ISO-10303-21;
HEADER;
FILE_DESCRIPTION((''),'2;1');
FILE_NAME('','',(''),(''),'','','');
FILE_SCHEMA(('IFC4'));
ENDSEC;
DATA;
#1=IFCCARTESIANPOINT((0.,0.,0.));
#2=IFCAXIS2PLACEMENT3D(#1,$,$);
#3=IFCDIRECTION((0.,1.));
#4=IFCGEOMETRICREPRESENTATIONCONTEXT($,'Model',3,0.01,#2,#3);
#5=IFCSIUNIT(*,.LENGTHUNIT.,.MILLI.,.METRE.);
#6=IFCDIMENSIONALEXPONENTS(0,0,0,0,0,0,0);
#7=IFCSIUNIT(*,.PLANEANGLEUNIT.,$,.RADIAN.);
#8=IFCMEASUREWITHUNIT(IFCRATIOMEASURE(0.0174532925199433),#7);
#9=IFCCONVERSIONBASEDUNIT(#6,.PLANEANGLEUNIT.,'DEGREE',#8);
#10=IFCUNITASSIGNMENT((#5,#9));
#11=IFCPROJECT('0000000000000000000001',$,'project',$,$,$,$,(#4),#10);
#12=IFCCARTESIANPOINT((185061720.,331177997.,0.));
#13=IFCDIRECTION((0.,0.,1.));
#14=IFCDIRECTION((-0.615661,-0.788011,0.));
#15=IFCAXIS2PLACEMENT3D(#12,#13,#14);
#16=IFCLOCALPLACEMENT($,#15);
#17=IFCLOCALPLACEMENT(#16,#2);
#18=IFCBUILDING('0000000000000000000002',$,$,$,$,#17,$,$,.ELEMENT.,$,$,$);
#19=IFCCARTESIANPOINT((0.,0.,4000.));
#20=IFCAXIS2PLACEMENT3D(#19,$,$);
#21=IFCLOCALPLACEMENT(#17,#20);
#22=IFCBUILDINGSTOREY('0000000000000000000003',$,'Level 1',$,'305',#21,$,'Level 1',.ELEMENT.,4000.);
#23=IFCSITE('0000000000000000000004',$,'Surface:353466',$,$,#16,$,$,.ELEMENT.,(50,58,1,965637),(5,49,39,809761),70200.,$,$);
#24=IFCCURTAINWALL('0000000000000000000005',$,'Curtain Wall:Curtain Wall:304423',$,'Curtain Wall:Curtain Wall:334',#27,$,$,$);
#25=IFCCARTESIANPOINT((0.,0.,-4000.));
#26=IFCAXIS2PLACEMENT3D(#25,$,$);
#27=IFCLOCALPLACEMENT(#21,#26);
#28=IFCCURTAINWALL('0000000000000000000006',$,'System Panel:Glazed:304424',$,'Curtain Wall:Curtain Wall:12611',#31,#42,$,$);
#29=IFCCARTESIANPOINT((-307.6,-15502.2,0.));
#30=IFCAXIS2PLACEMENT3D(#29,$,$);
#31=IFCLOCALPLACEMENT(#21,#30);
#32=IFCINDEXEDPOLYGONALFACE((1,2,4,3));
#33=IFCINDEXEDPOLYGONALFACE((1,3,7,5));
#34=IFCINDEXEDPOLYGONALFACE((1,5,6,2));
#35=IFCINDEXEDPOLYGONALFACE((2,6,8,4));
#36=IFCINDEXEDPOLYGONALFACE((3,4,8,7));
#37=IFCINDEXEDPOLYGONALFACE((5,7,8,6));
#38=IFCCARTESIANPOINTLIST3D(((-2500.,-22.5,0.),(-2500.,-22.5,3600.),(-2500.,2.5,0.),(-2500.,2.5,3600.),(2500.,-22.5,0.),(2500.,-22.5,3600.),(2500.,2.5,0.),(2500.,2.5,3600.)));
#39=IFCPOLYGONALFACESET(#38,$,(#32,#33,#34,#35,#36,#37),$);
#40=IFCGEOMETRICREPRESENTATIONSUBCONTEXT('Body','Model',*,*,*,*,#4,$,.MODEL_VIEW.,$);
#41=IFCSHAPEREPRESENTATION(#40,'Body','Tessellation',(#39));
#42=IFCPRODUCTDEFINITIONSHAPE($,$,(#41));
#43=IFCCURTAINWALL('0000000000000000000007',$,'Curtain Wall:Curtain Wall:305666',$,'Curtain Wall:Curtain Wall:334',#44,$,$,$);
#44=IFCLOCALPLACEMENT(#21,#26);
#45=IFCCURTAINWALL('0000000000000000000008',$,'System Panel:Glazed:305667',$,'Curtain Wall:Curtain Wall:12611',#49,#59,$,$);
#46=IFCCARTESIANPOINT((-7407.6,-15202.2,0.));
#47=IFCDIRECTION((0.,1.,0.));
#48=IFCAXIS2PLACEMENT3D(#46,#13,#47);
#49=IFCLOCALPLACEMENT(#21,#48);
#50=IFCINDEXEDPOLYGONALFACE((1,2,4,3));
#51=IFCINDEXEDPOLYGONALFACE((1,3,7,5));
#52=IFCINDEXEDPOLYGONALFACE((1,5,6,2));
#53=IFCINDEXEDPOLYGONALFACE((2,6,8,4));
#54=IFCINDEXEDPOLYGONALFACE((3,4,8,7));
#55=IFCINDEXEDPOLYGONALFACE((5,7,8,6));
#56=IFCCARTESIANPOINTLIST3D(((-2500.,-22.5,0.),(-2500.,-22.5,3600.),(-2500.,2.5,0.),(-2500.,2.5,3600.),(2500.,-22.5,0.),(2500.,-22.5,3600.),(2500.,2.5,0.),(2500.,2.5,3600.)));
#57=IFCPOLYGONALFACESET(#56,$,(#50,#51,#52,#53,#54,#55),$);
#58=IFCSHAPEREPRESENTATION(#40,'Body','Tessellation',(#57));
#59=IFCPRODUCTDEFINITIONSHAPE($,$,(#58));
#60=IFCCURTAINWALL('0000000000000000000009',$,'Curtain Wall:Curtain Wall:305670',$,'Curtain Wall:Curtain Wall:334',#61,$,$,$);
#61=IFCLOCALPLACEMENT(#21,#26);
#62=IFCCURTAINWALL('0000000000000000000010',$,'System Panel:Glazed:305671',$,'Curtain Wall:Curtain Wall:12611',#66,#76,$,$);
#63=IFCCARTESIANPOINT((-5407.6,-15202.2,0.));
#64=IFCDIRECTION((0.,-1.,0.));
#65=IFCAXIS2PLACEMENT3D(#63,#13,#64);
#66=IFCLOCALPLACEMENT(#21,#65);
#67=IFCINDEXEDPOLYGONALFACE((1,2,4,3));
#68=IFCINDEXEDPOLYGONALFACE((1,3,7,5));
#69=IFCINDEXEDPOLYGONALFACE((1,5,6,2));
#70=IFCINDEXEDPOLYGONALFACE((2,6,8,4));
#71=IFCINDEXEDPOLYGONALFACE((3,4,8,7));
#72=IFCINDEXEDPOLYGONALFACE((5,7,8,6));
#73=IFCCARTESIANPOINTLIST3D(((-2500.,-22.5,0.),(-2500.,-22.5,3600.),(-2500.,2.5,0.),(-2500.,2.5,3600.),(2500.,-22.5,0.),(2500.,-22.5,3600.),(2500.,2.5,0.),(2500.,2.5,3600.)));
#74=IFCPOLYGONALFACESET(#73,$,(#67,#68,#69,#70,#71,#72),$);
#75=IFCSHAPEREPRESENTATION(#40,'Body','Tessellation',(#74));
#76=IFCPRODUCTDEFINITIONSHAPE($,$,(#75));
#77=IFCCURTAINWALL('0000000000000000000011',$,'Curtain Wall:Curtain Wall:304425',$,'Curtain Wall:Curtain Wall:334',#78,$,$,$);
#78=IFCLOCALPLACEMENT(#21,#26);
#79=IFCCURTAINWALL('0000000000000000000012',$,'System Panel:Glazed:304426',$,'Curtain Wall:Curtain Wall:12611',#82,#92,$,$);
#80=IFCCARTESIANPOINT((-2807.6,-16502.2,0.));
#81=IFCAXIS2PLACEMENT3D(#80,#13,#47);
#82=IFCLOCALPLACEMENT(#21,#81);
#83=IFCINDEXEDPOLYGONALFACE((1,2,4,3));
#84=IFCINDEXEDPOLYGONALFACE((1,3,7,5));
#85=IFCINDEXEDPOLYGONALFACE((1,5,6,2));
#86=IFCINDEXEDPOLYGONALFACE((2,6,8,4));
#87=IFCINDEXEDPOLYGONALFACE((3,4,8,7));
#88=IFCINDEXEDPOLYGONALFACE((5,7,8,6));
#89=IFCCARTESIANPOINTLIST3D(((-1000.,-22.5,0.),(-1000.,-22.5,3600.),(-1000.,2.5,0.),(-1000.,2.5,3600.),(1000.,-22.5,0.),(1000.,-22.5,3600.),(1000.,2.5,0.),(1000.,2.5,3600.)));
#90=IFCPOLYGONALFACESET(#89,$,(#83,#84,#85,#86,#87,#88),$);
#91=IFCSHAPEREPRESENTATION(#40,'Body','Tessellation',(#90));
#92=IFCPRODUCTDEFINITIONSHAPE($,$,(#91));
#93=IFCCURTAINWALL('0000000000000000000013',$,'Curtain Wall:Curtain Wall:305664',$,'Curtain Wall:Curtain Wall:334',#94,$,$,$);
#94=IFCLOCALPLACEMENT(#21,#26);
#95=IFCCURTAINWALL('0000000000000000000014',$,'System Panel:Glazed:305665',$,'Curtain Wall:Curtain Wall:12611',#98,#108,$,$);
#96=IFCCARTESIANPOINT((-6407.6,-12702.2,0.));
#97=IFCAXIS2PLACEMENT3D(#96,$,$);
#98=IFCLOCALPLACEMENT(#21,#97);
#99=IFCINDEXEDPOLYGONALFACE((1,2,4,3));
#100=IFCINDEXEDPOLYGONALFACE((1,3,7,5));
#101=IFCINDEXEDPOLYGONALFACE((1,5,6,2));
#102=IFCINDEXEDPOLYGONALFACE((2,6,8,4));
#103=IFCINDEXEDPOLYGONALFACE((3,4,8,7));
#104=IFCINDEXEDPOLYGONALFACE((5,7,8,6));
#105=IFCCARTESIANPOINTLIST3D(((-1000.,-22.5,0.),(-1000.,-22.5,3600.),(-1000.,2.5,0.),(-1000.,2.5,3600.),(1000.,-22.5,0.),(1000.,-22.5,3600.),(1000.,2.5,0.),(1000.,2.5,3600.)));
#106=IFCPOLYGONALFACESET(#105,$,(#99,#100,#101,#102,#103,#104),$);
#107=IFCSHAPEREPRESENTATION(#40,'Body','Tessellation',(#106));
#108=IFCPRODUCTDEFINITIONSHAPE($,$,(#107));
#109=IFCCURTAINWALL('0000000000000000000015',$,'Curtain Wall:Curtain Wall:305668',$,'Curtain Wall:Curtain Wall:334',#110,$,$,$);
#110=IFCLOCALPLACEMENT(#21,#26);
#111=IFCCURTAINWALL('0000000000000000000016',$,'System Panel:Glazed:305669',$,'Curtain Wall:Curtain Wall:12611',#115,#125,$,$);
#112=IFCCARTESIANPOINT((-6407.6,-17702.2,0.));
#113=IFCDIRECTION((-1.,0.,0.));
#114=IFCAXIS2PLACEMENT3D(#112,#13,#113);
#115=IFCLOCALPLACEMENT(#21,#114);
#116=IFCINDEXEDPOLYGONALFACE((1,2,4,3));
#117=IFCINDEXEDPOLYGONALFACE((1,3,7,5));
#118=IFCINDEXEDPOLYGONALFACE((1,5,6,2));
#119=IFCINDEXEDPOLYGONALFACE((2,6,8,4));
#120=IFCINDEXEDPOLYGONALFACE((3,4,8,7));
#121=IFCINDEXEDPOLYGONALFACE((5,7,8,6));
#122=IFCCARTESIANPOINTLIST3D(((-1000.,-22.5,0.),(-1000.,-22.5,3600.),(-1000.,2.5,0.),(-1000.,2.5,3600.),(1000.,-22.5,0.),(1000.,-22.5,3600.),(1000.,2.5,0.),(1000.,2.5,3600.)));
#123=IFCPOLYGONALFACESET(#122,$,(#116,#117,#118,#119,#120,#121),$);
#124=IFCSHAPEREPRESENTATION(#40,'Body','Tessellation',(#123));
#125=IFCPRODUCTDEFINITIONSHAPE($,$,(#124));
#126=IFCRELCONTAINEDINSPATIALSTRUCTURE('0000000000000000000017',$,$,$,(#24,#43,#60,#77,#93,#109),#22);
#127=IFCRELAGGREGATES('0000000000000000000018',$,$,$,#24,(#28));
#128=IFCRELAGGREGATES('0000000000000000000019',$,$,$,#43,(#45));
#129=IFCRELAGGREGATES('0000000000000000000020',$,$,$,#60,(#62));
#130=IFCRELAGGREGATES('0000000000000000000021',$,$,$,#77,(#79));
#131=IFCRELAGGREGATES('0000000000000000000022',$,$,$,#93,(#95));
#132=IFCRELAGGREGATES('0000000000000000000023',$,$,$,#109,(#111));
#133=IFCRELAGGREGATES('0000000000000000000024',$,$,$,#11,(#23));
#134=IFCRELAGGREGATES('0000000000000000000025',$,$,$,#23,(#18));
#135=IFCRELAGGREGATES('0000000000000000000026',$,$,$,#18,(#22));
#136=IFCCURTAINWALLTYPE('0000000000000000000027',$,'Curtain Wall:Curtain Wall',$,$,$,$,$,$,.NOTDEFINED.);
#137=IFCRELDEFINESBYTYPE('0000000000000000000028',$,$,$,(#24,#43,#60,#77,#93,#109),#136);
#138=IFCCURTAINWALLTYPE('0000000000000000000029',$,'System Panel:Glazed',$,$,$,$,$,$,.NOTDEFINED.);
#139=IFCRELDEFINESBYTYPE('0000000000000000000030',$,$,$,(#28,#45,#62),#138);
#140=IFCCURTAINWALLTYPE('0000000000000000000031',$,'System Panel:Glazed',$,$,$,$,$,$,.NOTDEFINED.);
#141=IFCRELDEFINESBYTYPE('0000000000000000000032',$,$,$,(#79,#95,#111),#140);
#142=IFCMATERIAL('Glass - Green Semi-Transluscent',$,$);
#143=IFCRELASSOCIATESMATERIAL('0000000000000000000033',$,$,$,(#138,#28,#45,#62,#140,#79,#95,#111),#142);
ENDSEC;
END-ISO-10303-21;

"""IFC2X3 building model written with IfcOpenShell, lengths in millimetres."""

from ifc_helpers import new_model, entity, si_unit, converted_unit, direction, frame, origin, origin_2d_with_axis, place, context, subcontext, project, spatial, rectangle, extrude, source, transform, mapped, material, type_object, type_shapes, element, aggregate, save


model = new_model("IFC2X3")

# Units and contexts
model_context = context("Model", 3, precision=0.01, world=origin(), true_north=direction((0.0, 1.0)))
body_context = subcontext(model_context, "Body", "Model", "MODEL_VIEW")
ifc_project = project(units=[si_unit("LENGTHUNIT", "METRE", prefix="MILLI"), converted_unit("PLANEANGLEUNIT", "DEGREE", entity("IfcRatioMeasure", 0.0174532925199433), si_unit("PLANEANGLEUNIT", "RADIAN"), dimensions=[0, 0, 0, 0, 0, 0, 0])], contexts=[model_context])

# Site, building, storey
site_placement = place(None, frame((185061720.0, 331177997.0, 0.0), z_axis=(0.0, 0.0, 1.0), x_axis=(-0.615661, -0.788011, 0.0)))
site = spatial("IfcSite", under=ifc_project, at=site_placement, Name="Surface:353466", CompositionType="ELEMENT", RefLatitude=(50, 58, 1, 965637), RefLongitude=(5, 49, 39, 809761), RefElevation=70200.0)
building_placement = place(site_placement, origin())
building = spatial("IfcBuilding", under=site, at=building_placement, CompositionType="ELEMENT")
storey_placement = place(building_placement, frame((0.0, 0.0, 4000.0)))
storey = spatial("IfcBuildingStorey", under=building, at=storey_placement, Name="Level 1", ObjectType="305", LongName="Level 1", CompositionType="ELEMENT", Elevation=4000.0)

# Curtain walls
curtain_wall_type_1 = type_object("IfcCurtainWallType", Name="Curtain Wall:Curtain Wall", PredefinedType="NOTDEFINED")
curtain_wall_1_placement = place(storey_placement, frame((0.0, 0.0, -4000.0)))
curtain_wall_1 = element("IfcCurtainWall", 1, at=curtain_wall_1_placement, inside=storey, type_object=curtain_wall_type_1, Name="Curtain Wall:Curtain Wall:304423", ObjectType="Curtain Wall:Curtain Wall:334")
ifc_material_1 = material(Name="Glass - Green Semi-Transluscent")
curtain_wall_type_2 = type_object("IfcCurtainWallType", Name="System Panel:Glazed", PredefinedType="NOTDEFINED", material=ifc_material_1)
shared_shape_1 = source(origin(), body_context, "Body", "SweptSolid", [
    extrude(rectangle(XDim=25.0, YDim=5000.0, at=origin_2d_with_axis()), frame((0.0, -10.0, 0.0), z_axis=(0.0, 0.0, 1.0), x_axis=(0.0, 1.0, 0.0)), (0.0, 0.0, 1.0), 3600.0),
])
type_shapes(curtain_wall_type_2, [shared_shape_1])
curtain_wall_2_placement = place(storey_placement, frame((-307.6, -15502.2, 0.0)))
curtain_wall_2 = element("IfcCurtainWall", 2, at=curtain_wall_2_placement, type_object=curtain_wall_type_2, material=ifc_material_1, Name="System Panel:Glazed:304424", ObjectType="Curtain Wall:Curtain Wall:12611", context=body_context, shape_type="MappedRepresentation", body=[
    mapped(shared_shape_1, transform((0.0, 0.0, 0.0), scale=1.0)),
])
aggregate(curtain_wall_1, [curtain_wall_2])
curtain_wall_3_placement = place(storey_placement, frame((0.0, 0.0, -4000.0)))
curtain_wall_3 = element("IfcCurtainWall", 3, at=curtain_wall_3_placement, inside=storey, type_object=curtain_wall_type_1, Name="Curtain Wall:Curtain Wall:305666", ObjectType="Curtain Wall:Curtain Wall:334")
curtain_wall_4_placement = place(storey_placement, frame((-7407.6, -15202.2, 0.0), z_axis=(0.0, 0.0, 1.0), x_axis=(0.0, 1.0, 0.0)))
curtain_wall_4 = element("IfcCurtainWall", 4, at=curtain_wall_4_placement, type_object=curtain_wall_type_2, material=ifc_material_1, Name="System Panel:Glazed:305667", ObjectType="Curtain Wall:Curtain Wall:12611", context=body_context, shape_type="MappedRepresentation", body=[
    mapped(shared_shape_1, transform((0.0, 0.0, 0.0), scale=1.0)),
])
aggregate(curtain_wall_3, [curtain_wall_4])
curtain_wall_5_placement = place(storey_placement, frame((0.0, 0.0, -4000.0)))
curtain_wall_5 = element("IfcCurtainWall", 5, at=curtain_wall_5_placement, inside=storey, type_object=curtain_wall_type_1, Name="Curtain Wall:Curtain Wall:305670", ObjectType="Curtain Wall:Curtain Wall:334")
curtain_wall_6_placement = place(storey_placement, frame((-5407.6, -15202.2, 0.0), z_axis=(0.0, 0.0, 1.0), x_axis=(0.0, -1.0, 0.0)))
curtain_wall_6 = element("IfcCurtainWall", 6, at=curtain_wall_6_placement, type_object=curtain_wall_type_2, material=ifc_material_1, Name="System Panel:Glazed:305671", ObjectType="Curtain Wall:Curtain Wall:12611", context=body_context, shape_type="MappedRepresentation", body=[
    mapped(shared_shape_1, transform((0.0, 0.0, 0.0), scale=1.0)),
])
aggregate(curtain_wall_5, [curtain_wall_6])
curtain_wall_7_placement = place(storey_placement, frame((0.0, 0.0, -4000.0)))
curtain_wall_7 = element("IfcCurtainWall", 7, at=curtain_wall_7_placement, inside=storey, type_object=curtain_wall_type_1, Name="Curtain Wall:Curtain Wall:304425", ObjectType="Curtain Wall:Curtain Wall:334")
curtain_wall_type_3 = type_object("IfcCurtainWallType", Name="System Panel:Glazed", PredefinedType="NOTDEFINED", material=ifc_material_1)
shared_shape_2 = source(origin(), body_context, "Body", "SweptSolid", [
    extrude(rectangle(XDim=25.0, YDim=2000.0, at=origin_2d_with_axis()), frame((0.0, -10.0, 0.0), z_axis=(0.0, 0.0, 1.0), x_axis=(0.0, 1.0, 0.0)), (0.0, 0.0, 1.0), 3600.0),
])
type_shapes(curtain_wall_type_3, [shared_shape_2])
curtain_wall_8_placement = place(storey_placement, frame((-2807.6, -16502.2, 0.0), z_axis=(0.0, 0.0, 1.0), x_axis=(0.0, 1.0, 0.0)))
curtain_wall_8 = element("IfcCurtainWall", 8, at=curtain_wall_8_placement, type_object=curtain_wall_type_3, material=ifc_material_1, Name="System Panel:Glazed:304426", ObjectType="Curtain Wall:Curtain Wall:12611", context=body_context, shape_type="MappedRepresentation", body=[
    mapped(shared_shape_2, transform((0.0, 0.0, 0.0), scale=1.0)),
])
aggregate(curtain_wall_7, [curtain_wall_8])
curtain_wall_9_placement = place(storey_placement, frame((0.0, 0.0, -4000.0)))
curtain_wall_9 = element("IfcCurtainWall", 9, at=curtain_wall_9_placement, inside=storey, type_object=curtain_wall_type_1, Name="Curtain Wall:Curtain Wall:305664", ObjectType="Curtain Wall:Curtain Wall:334")
curtain_wall_10_placement = place(storey_placement, frame((-6407.6, -12702.2, 0.0)))
curtain_wall_10 = element("IfcCurtainWall", 10, at=curtain_wall_10_placement, type_object=curtain_wall_type_3, material=ifc_material_1, Name="System Panel:Glazed:305665", ObjectType="Curtain Wall:Curtain Wall:12611", context=body_context, shape_type="MappedRepresentation", body=[
    mapped(shared_shape_2, transform((0.0, 0.0, 0.0), scale=1.0)),
])
aggregate(curtain_wall_9, [curtain_wall_10])
curtain_wall_11_placement = place(storey_placement, frame((0.0, 0.0, -4000.0)))
curtain_wall_11 = element("IfcCurtainWall", 11, at=curtain_wall_11_placement, inside=storey, type_object=curtain_wall_type_1, Name="Curtain Wall:Curtain Wall:305668", ObjectType="Curtain Wall:Curtain Wall:334")
curtain_wall_12_placement = place(storey_placement, frame((-6407.6, -17702.2, 0.0), z_axis=(0.0, 0.0, 1.0), x_axis=(-1.0, 0.0, 0.0)))
curtain_wall_12 = element("IfcCurtainWall", 12, at=curtain_wall_12_placement, type_object=curtain_wall_type_3, material=ifc_material_1, Name="System Panel:Glazed:305669", ObjectType="Curtain Wall:Curtain Wall:12611", context=body_context, shape_type="MappedRepresentation", body=[
    mapped(shared_shape_2, transform((0.0, 0.0, 0.0), scale=1.0)),
])
aggregate(curtain_wall_11, [curtain_wall_12])

save(model, "model.ifc")
